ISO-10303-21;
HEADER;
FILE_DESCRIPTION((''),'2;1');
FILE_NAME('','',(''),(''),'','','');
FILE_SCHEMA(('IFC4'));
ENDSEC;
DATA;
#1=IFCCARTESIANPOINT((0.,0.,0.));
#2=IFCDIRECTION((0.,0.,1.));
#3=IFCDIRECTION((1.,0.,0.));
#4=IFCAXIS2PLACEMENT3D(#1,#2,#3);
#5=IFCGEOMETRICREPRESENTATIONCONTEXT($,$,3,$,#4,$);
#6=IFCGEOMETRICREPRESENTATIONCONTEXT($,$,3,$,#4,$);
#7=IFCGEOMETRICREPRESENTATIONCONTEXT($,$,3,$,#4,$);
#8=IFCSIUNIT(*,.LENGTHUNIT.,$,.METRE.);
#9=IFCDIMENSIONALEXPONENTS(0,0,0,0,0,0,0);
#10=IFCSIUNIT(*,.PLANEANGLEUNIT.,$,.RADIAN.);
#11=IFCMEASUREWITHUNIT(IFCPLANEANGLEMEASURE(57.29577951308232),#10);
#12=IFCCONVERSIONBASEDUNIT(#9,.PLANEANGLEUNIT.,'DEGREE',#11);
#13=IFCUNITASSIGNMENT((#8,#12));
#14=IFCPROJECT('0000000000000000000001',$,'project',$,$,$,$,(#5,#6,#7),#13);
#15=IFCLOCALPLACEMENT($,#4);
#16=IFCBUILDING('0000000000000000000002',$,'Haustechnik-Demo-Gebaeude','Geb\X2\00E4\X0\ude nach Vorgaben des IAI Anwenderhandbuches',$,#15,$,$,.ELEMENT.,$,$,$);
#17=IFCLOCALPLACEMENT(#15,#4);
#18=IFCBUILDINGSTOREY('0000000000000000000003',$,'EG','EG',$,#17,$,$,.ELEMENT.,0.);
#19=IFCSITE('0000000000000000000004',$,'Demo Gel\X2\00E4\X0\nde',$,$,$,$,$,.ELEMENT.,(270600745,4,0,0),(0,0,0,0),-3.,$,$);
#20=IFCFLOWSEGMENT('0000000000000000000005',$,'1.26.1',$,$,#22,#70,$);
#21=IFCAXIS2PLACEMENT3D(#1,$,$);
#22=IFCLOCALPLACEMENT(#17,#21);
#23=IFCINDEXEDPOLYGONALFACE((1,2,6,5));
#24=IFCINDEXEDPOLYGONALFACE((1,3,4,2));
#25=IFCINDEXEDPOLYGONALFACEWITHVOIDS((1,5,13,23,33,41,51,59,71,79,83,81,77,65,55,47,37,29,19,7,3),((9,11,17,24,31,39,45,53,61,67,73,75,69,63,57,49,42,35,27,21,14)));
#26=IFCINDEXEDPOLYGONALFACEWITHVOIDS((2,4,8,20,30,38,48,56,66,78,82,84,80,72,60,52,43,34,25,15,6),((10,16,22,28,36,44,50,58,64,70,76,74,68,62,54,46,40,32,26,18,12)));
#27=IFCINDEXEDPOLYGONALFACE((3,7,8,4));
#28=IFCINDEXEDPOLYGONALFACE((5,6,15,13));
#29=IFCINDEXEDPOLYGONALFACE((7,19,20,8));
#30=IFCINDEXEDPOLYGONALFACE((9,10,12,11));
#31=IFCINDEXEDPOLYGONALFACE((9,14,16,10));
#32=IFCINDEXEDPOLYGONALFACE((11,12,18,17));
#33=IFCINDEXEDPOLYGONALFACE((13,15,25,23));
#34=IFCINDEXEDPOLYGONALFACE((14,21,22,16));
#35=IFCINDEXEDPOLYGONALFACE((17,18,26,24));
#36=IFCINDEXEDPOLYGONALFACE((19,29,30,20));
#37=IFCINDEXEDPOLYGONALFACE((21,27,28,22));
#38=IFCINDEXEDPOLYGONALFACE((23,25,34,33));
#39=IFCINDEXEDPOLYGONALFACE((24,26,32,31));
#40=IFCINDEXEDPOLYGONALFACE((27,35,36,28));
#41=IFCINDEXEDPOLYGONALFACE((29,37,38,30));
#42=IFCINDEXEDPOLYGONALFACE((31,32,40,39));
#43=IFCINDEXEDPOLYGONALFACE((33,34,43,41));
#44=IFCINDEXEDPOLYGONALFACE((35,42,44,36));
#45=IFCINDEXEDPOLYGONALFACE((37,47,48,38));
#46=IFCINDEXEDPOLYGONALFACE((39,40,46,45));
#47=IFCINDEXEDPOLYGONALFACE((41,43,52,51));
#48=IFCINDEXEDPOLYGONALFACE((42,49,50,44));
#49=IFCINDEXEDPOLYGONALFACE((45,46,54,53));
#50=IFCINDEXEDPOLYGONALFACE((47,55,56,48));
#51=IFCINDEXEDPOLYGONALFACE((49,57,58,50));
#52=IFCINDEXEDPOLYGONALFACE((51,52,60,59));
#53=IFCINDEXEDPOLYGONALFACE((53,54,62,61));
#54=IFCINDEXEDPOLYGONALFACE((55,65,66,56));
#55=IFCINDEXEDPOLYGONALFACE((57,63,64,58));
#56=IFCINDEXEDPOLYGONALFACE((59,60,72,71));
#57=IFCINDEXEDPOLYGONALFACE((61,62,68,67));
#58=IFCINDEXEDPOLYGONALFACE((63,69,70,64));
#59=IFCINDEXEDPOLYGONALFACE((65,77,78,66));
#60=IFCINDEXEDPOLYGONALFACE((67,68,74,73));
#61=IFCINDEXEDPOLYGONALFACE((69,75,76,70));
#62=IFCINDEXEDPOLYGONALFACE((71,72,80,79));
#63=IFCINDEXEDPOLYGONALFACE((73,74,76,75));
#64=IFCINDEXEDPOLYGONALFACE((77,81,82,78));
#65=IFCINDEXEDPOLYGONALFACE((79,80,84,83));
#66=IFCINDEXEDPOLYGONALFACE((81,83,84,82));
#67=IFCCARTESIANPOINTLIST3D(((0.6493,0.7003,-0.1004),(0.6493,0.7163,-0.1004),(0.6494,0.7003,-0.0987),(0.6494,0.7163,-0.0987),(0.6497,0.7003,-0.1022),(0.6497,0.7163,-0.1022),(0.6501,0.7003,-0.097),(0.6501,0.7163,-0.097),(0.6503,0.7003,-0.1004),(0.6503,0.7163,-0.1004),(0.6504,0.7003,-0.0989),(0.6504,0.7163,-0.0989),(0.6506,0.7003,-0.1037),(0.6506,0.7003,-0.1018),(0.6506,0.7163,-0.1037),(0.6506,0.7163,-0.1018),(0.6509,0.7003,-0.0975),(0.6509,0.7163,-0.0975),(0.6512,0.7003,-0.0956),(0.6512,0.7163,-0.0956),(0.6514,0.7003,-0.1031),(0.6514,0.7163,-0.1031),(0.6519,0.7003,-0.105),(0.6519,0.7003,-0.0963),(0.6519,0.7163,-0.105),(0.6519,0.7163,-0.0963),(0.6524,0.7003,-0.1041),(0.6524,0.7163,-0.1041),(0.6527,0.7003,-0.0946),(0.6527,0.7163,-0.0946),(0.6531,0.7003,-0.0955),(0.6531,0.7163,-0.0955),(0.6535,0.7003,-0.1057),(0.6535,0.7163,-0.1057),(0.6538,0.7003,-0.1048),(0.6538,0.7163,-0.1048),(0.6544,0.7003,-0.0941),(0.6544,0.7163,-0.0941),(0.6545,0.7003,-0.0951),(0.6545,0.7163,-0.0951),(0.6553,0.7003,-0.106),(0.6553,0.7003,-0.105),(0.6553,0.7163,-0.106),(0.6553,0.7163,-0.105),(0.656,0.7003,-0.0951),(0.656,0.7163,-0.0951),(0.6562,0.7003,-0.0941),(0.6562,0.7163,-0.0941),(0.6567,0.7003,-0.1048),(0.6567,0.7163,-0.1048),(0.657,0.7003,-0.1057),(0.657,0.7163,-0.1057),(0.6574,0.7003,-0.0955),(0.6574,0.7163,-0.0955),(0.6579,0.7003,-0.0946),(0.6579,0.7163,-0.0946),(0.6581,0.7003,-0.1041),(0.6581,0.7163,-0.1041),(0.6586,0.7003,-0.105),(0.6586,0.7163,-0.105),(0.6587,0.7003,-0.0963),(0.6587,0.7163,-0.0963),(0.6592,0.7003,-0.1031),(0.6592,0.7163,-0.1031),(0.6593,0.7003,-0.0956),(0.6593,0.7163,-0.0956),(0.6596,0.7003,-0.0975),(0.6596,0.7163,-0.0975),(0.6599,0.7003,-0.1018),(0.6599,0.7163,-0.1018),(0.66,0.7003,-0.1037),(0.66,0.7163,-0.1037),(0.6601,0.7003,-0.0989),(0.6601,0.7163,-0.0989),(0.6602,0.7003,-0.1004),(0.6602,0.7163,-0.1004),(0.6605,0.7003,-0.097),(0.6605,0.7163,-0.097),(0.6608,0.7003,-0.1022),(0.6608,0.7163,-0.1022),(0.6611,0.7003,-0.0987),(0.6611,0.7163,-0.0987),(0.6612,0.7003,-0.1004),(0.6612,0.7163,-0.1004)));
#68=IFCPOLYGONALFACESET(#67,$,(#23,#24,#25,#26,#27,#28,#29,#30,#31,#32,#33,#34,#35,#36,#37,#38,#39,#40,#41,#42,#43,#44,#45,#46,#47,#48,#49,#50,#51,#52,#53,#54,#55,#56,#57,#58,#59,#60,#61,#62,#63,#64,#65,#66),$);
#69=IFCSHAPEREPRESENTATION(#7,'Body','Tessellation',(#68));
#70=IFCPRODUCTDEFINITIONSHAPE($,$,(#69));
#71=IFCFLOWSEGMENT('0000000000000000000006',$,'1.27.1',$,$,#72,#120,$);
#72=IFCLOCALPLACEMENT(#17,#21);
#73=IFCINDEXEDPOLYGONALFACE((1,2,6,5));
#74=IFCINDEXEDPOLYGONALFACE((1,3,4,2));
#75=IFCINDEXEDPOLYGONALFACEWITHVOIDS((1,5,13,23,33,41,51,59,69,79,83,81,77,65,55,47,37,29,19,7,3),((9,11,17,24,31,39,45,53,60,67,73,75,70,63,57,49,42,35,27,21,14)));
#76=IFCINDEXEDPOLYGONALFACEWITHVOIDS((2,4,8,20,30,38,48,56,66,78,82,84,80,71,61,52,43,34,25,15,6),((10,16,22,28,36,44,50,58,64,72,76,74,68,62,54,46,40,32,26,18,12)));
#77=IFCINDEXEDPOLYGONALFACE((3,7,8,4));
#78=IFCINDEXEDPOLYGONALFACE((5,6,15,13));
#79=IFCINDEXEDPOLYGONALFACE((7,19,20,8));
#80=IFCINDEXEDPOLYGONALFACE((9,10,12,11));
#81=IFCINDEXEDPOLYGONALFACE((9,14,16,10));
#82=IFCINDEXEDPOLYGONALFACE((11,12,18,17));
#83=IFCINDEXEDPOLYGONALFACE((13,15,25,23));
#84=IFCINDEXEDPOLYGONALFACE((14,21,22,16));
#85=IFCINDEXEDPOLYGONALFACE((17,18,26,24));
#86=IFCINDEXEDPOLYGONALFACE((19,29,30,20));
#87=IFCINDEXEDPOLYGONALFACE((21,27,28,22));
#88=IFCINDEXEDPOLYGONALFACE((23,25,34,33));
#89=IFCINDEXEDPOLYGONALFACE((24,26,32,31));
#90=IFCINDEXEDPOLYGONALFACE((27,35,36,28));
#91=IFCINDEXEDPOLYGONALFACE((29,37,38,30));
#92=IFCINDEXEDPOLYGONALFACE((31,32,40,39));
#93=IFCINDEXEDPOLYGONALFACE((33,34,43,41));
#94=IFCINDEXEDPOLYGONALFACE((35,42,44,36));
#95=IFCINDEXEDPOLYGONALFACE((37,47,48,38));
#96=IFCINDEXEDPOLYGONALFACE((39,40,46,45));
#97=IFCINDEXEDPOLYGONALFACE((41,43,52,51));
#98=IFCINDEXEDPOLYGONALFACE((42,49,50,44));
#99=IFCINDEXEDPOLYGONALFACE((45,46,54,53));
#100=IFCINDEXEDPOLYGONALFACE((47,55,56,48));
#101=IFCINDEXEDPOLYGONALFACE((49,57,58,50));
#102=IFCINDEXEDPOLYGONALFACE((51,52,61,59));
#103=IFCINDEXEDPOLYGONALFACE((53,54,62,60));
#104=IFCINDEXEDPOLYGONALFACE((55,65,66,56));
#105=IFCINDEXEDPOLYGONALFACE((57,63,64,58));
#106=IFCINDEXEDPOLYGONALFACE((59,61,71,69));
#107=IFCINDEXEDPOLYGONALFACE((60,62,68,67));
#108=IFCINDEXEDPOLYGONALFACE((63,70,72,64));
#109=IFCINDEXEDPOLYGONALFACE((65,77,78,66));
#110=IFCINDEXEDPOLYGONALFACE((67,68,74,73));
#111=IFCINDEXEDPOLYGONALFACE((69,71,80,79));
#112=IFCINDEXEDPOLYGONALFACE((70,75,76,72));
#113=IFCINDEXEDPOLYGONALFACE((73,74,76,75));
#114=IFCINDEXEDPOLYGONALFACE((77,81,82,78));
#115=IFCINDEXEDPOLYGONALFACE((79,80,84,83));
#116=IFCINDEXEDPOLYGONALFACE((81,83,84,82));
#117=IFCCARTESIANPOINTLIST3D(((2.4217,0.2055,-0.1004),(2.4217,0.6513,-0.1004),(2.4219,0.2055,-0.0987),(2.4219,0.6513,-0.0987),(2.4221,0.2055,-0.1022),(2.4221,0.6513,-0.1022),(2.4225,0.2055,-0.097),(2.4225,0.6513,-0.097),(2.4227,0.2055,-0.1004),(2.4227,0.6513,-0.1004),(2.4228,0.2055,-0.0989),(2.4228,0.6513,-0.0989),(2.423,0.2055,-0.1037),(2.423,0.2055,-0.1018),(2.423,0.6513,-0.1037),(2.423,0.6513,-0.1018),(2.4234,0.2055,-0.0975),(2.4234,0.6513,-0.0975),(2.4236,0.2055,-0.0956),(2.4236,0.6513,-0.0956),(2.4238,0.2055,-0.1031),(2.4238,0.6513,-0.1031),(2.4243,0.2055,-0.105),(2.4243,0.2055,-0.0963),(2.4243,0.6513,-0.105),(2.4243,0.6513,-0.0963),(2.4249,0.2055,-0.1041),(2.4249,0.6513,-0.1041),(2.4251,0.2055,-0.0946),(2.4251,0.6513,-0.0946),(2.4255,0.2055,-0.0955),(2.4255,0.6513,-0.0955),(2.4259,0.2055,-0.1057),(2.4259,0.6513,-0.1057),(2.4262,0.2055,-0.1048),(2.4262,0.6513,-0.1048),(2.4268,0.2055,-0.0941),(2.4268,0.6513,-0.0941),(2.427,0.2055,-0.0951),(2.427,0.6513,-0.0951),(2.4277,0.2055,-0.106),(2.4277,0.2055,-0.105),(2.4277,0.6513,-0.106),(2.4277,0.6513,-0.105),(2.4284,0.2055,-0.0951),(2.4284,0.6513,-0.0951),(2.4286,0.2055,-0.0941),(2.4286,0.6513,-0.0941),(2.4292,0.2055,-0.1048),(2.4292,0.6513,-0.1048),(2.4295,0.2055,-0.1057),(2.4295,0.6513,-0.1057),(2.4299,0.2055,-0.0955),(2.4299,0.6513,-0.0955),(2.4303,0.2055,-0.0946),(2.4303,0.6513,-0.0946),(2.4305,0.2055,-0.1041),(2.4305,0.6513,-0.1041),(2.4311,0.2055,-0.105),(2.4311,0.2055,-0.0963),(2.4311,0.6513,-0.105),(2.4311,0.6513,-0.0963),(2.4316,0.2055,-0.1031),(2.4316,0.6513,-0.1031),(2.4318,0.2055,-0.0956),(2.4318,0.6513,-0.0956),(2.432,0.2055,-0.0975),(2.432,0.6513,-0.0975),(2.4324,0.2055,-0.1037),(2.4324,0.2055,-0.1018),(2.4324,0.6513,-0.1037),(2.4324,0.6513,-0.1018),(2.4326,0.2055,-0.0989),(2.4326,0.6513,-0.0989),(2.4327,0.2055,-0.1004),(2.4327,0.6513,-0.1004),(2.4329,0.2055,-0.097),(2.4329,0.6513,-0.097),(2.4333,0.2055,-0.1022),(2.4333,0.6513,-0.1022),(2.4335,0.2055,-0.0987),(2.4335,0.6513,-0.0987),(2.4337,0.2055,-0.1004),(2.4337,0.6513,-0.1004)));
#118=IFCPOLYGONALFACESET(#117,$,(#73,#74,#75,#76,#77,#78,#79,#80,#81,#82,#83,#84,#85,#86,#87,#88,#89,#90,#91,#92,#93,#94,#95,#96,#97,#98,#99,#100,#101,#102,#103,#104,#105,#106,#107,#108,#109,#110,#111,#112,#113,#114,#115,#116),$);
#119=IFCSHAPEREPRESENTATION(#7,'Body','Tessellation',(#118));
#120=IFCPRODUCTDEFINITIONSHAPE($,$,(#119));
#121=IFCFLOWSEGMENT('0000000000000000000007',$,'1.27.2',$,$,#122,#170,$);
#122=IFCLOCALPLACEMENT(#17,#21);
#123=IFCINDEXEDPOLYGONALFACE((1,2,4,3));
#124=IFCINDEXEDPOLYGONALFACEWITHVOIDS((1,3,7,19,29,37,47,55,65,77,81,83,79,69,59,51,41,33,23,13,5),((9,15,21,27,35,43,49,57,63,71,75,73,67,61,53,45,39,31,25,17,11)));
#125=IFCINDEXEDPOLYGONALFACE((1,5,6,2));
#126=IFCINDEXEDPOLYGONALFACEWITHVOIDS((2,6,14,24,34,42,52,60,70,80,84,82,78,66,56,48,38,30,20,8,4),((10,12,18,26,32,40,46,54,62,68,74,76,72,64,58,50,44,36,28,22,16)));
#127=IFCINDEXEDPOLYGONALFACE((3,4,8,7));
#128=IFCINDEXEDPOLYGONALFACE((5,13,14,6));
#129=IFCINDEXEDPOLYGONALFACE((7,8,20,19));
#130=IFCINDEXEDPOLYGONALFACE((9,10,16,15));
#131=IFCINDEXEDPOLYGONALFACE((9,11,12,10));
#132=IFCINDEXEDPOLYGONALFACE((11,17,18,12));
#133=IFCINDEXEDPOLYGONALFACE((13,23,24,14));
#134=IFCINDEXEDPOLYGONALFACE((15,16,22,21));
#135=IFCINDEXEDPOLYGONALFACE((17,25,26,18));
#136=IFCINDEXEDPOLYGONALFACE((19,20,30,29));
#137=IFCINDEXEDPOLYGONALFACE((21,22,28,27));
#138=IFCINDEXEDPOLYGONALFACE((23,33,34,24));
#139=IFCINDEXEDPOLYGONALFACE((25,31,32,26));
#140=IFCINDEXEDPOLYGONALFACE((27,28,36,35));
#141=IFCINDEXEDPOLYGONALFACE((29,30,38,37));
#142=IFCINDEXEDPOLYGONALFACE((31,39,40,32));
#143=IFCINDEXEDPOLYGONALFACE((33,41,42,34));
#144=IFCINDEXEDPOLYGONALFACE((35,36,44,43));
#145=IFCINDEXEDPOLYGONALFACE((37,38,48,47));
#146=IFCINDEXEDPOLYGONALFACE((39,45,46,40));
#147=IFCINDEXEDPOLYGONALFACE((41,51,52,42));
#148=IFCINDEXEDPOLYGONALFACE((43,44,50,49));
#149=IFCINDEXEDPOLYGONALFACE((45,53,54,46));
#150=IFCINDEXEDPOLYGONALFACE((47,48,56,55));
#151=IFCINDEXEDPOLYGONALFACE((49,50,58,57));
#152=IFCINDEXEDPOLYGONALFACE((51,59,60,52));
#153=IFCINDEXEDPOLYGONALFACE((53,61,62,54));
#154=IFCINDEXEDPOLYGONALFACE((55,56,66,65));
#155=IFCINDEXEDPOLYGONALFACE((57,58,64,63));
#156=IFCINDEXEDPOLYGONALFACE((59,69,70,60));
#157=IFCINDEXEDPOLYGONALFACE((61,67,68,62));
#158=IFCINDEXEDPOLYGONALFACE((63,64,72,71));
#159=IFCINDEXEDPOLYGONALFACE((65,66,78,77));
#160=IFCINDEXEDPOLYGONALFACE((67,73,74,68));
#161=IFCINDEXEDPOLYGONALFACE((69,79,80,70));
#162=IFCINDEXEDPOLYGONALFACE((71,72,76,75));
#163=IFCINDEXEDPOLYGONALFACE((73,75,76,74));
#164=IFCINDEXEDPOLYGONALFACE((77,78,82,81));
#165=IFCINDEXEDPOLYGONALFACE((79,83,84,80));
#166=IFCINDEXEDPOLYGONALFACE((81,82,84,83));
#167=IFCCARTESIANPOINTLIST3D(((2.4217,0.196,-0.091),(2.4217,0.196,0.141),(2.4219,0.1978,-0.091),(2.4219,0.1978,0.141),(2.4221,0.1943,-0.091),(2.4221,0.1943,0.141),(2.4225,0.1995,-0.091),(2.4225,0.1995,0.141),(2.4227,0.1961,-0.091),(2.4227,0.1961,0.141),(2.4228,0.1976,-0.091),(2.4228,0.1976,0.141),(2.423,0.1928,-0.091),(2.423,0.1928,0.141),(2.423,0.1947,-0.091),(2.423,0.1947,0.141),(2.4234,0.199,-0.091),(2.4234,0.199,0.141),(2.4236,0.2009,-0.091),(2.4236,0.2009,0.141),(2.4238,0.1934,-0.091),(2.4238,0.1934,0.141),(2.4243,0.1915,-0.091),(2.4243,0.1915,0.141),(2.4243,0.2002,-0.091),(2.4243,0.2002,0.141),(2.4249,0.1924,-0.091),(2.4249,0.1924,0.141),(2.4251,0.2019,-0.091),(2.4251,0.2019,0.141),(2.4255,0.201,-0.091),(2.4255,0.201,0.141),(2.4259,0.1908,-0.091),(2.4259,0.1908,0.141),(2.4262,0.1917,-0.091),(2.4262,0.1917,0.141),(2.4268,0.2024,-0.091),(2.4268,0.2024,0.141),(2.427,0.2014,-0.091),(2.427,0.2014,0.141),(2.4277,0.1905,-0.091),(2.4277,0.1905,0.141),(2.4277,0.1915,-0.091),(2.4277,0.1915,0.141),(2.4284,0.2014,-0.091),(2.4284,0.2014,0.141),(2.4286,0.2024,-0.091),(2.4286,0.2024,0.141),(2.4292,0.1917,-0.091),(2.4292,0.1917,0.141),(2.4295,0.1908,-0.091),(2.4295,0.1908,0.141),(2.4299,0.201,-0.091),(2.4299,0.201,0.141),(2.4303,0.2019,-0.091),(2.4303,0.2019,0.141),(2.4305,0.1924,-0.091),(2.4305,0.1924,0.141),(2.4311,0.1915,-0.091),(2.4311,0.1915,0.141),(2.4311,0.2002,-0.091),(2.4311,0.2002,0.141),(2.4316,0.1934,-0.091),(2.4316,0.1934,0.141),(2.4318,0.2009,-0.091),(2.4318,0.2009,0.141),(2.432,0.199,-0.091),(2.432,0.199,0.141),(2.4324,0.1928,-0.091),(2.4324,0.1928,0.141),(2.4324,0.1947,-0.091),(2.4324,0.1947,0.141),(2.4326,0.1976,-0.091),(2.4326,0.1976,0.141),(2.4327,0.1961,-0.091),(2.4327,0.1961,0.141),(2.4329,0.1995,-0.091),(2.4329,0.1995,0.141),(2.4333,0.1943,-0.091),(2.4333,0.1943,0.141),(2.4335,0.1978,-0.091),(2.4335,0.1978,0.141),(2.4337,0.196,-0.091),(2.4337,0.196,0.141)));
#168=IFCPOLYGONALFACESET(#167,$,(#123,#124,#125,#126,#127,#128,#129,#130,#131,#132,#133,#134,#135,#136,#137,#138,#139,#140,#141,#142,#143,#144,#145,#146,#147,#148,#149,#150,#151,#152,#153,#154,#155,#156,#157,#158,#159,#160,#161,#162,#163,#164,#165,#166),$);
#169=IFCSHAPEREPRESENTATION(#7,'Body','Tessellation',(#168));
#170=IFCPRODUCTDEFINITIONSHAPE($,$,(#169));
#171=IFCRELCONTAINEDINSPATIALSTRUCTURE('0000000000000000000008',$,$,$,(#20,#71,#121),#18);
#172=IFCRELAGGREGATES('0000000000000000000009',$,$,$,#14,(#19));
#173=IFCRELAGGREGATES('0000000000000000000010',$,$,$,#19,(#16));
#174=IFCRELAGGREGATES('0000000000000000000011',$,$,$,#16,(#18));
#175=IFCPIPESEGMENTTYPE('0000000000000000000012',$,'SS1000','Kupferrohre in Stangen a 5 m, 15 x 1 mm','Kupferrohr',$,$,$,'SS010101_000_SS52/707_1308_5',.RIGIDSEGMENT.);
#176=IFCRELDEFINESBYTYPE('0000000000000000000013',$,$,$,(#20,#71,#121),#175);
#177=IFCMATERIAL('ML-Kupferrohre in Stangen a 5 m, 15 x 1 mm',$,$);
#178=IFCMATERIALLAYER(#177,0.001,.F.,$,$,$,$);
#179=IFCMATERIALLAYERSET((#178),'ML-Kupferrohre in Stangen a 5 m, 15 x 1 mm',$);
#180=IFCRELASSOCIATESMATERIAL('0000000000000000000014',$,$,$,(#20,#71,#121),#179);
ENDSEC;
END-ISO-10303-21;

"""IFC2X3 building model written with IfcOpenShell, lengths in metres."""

from ifc_helpers import new_model, entity, si_unit, converted_unit, frame, origin_with_axes, origin_2d_with_axis, place, context, project, spatial, hollow_circle, extrude, material, layer, layer_set, layer_usage, type_object, element, save


model = new_model("IFC2X3")

# Units and contexts
context_of_model_1 = context(None, 3, world=origin_with_axes())
context_of_model_2 = context(None, 3, world=origin_with_axes())
context_of_model_3 = context(None, 3, world=origin_with_axes())
ifc_project = project(units=[si_unit("LENGTHUNIT", "METRE"), converted_unit("PLANEANGLEUNIT", "DEGREE", entity("IfcPlaneAngleMeasure", 57.29577951308232), si_unit("PLANEANGLEUNIT", "RADIAN"), dimensions=[0, 0, 0, 0, 0, 0, 0])], contexts=[context_of_model_1, context_of_model_2, context_of_model_3])

# Site, building, storey
site = spatial("IfcSite", under=ifc_project, Name="Demo Gelände", CompositionType="ELEMENT", RefLatitude=(270600745, 4, 0, 0), RefLongitude=(0, 0, 0, 0), RefElevation=-3.0)
building_placement = place(None, origin_with_axes())
building = spatial("IfcBuilding", under=site, at=building_placement, Name="Haustechnik-Demo-Gebaeude", Description="Gebäude nach Vorgaben des IAI Anwenderhandbuches", CompositionType="ELEMENT")
storey_placement = place(building_placement, origin_with_axes())
storey = spatial("IfcBuildingStorey", under=building, at=storey_placement, Name="EG", Description="EG", CompositionType="ELEMENT", Elevation=0.0)

# Flow segments
ifc_material = material(Name="ML-Kupferrohre in Stangen a 5 m, 15 x 1 mm")
ifc_layer = layer(ifc_material, 0.001, ventilated=False)
ifc_layer_set = layer_set([ifc_layer], Name="ML-Kupferrohre in Stangen a 5 m, 15 x 1 mm")
ifc_layer_usage = layer_usage(ifc_layer_set, "AXIS2", "POSITIVE", 0.0)
pipe_segment_type_1 = type_object("IfcPipeSegmentType", Name="SS1000", Description="Kupferrohre in Stangen a 5 m, 15 x 1 mm", ApplicableOccurrence="Kupferrohr", ElementType="SS010101_000_SS52/707_1308_5", PredefinedType="RIGIDSEGMENT")
flow_segment_1_placement = place(storey_placement, frame((0.6553, 0.7003, -0.1), z_axis=(0.0, 1.0, 0.0), x_axis=(0.0, 0.0, -1.0)))
element("IfcFlowSegment", 1, at=flow_segment_1_placement, inside=storey, type_object=pipe_segment_type_1, material=ifc_layer_usage, Name="1.26.1", context=context_of_model_3, shape_type="SweptSolid", body=[
    extrude(hollow_circle(Radius=0.006, WallThickness=0.001, at=origin_2d_with_axis()), origin_with_axes(), (0.0, 0.0, 1.0), 0.016),
])
flow_segment_2_placement = place(storey_placement, frame((2.4277, 0.6513, -0.1), z_axis=(0.0, -1.0, 0.0), x_axis=(0.0, 0.0, -1.0)))
element("IfcFlowSegment", 2, at=flow_segment_2_placement, inside=storey, type_object=pipe_segment_type_1, material=ifc_layer_usage, Name="1.27.1", context=context_of_model_3, shape_type="SweptSolid", body=[
    extrude(hollow_circle(Radius=0.006, WallThickness=0.001, at=origin_2d_with_axis()), origin_with_axes(), (0.0, 0.0, 1.0), 0.4458),
])
flow_segment_3_placement = place(storey_placement, frame((2.4277, 0.1965, -0.091), z_axis=(0.0, 0.0, 1.0), x_axis=(0.0, -1.0, 0.0)))
element("IfcFlowSegment", 3, at=flow_segment_3_placement, inside=storey, type_object=pipe_segment_type_1, material=ifc_layer_usage, Name="1.27.2", context=context_of_model_3, shape_type="SweptSolid", body=[
    extrude(hollow_circle(Radius=0.006, WallThickness=0.001, at=origin_2d_with_axis()), origin_with_axes(), (0.0, 0.0, 1.0), 0.232),
])

save(model, "model.ifc")
